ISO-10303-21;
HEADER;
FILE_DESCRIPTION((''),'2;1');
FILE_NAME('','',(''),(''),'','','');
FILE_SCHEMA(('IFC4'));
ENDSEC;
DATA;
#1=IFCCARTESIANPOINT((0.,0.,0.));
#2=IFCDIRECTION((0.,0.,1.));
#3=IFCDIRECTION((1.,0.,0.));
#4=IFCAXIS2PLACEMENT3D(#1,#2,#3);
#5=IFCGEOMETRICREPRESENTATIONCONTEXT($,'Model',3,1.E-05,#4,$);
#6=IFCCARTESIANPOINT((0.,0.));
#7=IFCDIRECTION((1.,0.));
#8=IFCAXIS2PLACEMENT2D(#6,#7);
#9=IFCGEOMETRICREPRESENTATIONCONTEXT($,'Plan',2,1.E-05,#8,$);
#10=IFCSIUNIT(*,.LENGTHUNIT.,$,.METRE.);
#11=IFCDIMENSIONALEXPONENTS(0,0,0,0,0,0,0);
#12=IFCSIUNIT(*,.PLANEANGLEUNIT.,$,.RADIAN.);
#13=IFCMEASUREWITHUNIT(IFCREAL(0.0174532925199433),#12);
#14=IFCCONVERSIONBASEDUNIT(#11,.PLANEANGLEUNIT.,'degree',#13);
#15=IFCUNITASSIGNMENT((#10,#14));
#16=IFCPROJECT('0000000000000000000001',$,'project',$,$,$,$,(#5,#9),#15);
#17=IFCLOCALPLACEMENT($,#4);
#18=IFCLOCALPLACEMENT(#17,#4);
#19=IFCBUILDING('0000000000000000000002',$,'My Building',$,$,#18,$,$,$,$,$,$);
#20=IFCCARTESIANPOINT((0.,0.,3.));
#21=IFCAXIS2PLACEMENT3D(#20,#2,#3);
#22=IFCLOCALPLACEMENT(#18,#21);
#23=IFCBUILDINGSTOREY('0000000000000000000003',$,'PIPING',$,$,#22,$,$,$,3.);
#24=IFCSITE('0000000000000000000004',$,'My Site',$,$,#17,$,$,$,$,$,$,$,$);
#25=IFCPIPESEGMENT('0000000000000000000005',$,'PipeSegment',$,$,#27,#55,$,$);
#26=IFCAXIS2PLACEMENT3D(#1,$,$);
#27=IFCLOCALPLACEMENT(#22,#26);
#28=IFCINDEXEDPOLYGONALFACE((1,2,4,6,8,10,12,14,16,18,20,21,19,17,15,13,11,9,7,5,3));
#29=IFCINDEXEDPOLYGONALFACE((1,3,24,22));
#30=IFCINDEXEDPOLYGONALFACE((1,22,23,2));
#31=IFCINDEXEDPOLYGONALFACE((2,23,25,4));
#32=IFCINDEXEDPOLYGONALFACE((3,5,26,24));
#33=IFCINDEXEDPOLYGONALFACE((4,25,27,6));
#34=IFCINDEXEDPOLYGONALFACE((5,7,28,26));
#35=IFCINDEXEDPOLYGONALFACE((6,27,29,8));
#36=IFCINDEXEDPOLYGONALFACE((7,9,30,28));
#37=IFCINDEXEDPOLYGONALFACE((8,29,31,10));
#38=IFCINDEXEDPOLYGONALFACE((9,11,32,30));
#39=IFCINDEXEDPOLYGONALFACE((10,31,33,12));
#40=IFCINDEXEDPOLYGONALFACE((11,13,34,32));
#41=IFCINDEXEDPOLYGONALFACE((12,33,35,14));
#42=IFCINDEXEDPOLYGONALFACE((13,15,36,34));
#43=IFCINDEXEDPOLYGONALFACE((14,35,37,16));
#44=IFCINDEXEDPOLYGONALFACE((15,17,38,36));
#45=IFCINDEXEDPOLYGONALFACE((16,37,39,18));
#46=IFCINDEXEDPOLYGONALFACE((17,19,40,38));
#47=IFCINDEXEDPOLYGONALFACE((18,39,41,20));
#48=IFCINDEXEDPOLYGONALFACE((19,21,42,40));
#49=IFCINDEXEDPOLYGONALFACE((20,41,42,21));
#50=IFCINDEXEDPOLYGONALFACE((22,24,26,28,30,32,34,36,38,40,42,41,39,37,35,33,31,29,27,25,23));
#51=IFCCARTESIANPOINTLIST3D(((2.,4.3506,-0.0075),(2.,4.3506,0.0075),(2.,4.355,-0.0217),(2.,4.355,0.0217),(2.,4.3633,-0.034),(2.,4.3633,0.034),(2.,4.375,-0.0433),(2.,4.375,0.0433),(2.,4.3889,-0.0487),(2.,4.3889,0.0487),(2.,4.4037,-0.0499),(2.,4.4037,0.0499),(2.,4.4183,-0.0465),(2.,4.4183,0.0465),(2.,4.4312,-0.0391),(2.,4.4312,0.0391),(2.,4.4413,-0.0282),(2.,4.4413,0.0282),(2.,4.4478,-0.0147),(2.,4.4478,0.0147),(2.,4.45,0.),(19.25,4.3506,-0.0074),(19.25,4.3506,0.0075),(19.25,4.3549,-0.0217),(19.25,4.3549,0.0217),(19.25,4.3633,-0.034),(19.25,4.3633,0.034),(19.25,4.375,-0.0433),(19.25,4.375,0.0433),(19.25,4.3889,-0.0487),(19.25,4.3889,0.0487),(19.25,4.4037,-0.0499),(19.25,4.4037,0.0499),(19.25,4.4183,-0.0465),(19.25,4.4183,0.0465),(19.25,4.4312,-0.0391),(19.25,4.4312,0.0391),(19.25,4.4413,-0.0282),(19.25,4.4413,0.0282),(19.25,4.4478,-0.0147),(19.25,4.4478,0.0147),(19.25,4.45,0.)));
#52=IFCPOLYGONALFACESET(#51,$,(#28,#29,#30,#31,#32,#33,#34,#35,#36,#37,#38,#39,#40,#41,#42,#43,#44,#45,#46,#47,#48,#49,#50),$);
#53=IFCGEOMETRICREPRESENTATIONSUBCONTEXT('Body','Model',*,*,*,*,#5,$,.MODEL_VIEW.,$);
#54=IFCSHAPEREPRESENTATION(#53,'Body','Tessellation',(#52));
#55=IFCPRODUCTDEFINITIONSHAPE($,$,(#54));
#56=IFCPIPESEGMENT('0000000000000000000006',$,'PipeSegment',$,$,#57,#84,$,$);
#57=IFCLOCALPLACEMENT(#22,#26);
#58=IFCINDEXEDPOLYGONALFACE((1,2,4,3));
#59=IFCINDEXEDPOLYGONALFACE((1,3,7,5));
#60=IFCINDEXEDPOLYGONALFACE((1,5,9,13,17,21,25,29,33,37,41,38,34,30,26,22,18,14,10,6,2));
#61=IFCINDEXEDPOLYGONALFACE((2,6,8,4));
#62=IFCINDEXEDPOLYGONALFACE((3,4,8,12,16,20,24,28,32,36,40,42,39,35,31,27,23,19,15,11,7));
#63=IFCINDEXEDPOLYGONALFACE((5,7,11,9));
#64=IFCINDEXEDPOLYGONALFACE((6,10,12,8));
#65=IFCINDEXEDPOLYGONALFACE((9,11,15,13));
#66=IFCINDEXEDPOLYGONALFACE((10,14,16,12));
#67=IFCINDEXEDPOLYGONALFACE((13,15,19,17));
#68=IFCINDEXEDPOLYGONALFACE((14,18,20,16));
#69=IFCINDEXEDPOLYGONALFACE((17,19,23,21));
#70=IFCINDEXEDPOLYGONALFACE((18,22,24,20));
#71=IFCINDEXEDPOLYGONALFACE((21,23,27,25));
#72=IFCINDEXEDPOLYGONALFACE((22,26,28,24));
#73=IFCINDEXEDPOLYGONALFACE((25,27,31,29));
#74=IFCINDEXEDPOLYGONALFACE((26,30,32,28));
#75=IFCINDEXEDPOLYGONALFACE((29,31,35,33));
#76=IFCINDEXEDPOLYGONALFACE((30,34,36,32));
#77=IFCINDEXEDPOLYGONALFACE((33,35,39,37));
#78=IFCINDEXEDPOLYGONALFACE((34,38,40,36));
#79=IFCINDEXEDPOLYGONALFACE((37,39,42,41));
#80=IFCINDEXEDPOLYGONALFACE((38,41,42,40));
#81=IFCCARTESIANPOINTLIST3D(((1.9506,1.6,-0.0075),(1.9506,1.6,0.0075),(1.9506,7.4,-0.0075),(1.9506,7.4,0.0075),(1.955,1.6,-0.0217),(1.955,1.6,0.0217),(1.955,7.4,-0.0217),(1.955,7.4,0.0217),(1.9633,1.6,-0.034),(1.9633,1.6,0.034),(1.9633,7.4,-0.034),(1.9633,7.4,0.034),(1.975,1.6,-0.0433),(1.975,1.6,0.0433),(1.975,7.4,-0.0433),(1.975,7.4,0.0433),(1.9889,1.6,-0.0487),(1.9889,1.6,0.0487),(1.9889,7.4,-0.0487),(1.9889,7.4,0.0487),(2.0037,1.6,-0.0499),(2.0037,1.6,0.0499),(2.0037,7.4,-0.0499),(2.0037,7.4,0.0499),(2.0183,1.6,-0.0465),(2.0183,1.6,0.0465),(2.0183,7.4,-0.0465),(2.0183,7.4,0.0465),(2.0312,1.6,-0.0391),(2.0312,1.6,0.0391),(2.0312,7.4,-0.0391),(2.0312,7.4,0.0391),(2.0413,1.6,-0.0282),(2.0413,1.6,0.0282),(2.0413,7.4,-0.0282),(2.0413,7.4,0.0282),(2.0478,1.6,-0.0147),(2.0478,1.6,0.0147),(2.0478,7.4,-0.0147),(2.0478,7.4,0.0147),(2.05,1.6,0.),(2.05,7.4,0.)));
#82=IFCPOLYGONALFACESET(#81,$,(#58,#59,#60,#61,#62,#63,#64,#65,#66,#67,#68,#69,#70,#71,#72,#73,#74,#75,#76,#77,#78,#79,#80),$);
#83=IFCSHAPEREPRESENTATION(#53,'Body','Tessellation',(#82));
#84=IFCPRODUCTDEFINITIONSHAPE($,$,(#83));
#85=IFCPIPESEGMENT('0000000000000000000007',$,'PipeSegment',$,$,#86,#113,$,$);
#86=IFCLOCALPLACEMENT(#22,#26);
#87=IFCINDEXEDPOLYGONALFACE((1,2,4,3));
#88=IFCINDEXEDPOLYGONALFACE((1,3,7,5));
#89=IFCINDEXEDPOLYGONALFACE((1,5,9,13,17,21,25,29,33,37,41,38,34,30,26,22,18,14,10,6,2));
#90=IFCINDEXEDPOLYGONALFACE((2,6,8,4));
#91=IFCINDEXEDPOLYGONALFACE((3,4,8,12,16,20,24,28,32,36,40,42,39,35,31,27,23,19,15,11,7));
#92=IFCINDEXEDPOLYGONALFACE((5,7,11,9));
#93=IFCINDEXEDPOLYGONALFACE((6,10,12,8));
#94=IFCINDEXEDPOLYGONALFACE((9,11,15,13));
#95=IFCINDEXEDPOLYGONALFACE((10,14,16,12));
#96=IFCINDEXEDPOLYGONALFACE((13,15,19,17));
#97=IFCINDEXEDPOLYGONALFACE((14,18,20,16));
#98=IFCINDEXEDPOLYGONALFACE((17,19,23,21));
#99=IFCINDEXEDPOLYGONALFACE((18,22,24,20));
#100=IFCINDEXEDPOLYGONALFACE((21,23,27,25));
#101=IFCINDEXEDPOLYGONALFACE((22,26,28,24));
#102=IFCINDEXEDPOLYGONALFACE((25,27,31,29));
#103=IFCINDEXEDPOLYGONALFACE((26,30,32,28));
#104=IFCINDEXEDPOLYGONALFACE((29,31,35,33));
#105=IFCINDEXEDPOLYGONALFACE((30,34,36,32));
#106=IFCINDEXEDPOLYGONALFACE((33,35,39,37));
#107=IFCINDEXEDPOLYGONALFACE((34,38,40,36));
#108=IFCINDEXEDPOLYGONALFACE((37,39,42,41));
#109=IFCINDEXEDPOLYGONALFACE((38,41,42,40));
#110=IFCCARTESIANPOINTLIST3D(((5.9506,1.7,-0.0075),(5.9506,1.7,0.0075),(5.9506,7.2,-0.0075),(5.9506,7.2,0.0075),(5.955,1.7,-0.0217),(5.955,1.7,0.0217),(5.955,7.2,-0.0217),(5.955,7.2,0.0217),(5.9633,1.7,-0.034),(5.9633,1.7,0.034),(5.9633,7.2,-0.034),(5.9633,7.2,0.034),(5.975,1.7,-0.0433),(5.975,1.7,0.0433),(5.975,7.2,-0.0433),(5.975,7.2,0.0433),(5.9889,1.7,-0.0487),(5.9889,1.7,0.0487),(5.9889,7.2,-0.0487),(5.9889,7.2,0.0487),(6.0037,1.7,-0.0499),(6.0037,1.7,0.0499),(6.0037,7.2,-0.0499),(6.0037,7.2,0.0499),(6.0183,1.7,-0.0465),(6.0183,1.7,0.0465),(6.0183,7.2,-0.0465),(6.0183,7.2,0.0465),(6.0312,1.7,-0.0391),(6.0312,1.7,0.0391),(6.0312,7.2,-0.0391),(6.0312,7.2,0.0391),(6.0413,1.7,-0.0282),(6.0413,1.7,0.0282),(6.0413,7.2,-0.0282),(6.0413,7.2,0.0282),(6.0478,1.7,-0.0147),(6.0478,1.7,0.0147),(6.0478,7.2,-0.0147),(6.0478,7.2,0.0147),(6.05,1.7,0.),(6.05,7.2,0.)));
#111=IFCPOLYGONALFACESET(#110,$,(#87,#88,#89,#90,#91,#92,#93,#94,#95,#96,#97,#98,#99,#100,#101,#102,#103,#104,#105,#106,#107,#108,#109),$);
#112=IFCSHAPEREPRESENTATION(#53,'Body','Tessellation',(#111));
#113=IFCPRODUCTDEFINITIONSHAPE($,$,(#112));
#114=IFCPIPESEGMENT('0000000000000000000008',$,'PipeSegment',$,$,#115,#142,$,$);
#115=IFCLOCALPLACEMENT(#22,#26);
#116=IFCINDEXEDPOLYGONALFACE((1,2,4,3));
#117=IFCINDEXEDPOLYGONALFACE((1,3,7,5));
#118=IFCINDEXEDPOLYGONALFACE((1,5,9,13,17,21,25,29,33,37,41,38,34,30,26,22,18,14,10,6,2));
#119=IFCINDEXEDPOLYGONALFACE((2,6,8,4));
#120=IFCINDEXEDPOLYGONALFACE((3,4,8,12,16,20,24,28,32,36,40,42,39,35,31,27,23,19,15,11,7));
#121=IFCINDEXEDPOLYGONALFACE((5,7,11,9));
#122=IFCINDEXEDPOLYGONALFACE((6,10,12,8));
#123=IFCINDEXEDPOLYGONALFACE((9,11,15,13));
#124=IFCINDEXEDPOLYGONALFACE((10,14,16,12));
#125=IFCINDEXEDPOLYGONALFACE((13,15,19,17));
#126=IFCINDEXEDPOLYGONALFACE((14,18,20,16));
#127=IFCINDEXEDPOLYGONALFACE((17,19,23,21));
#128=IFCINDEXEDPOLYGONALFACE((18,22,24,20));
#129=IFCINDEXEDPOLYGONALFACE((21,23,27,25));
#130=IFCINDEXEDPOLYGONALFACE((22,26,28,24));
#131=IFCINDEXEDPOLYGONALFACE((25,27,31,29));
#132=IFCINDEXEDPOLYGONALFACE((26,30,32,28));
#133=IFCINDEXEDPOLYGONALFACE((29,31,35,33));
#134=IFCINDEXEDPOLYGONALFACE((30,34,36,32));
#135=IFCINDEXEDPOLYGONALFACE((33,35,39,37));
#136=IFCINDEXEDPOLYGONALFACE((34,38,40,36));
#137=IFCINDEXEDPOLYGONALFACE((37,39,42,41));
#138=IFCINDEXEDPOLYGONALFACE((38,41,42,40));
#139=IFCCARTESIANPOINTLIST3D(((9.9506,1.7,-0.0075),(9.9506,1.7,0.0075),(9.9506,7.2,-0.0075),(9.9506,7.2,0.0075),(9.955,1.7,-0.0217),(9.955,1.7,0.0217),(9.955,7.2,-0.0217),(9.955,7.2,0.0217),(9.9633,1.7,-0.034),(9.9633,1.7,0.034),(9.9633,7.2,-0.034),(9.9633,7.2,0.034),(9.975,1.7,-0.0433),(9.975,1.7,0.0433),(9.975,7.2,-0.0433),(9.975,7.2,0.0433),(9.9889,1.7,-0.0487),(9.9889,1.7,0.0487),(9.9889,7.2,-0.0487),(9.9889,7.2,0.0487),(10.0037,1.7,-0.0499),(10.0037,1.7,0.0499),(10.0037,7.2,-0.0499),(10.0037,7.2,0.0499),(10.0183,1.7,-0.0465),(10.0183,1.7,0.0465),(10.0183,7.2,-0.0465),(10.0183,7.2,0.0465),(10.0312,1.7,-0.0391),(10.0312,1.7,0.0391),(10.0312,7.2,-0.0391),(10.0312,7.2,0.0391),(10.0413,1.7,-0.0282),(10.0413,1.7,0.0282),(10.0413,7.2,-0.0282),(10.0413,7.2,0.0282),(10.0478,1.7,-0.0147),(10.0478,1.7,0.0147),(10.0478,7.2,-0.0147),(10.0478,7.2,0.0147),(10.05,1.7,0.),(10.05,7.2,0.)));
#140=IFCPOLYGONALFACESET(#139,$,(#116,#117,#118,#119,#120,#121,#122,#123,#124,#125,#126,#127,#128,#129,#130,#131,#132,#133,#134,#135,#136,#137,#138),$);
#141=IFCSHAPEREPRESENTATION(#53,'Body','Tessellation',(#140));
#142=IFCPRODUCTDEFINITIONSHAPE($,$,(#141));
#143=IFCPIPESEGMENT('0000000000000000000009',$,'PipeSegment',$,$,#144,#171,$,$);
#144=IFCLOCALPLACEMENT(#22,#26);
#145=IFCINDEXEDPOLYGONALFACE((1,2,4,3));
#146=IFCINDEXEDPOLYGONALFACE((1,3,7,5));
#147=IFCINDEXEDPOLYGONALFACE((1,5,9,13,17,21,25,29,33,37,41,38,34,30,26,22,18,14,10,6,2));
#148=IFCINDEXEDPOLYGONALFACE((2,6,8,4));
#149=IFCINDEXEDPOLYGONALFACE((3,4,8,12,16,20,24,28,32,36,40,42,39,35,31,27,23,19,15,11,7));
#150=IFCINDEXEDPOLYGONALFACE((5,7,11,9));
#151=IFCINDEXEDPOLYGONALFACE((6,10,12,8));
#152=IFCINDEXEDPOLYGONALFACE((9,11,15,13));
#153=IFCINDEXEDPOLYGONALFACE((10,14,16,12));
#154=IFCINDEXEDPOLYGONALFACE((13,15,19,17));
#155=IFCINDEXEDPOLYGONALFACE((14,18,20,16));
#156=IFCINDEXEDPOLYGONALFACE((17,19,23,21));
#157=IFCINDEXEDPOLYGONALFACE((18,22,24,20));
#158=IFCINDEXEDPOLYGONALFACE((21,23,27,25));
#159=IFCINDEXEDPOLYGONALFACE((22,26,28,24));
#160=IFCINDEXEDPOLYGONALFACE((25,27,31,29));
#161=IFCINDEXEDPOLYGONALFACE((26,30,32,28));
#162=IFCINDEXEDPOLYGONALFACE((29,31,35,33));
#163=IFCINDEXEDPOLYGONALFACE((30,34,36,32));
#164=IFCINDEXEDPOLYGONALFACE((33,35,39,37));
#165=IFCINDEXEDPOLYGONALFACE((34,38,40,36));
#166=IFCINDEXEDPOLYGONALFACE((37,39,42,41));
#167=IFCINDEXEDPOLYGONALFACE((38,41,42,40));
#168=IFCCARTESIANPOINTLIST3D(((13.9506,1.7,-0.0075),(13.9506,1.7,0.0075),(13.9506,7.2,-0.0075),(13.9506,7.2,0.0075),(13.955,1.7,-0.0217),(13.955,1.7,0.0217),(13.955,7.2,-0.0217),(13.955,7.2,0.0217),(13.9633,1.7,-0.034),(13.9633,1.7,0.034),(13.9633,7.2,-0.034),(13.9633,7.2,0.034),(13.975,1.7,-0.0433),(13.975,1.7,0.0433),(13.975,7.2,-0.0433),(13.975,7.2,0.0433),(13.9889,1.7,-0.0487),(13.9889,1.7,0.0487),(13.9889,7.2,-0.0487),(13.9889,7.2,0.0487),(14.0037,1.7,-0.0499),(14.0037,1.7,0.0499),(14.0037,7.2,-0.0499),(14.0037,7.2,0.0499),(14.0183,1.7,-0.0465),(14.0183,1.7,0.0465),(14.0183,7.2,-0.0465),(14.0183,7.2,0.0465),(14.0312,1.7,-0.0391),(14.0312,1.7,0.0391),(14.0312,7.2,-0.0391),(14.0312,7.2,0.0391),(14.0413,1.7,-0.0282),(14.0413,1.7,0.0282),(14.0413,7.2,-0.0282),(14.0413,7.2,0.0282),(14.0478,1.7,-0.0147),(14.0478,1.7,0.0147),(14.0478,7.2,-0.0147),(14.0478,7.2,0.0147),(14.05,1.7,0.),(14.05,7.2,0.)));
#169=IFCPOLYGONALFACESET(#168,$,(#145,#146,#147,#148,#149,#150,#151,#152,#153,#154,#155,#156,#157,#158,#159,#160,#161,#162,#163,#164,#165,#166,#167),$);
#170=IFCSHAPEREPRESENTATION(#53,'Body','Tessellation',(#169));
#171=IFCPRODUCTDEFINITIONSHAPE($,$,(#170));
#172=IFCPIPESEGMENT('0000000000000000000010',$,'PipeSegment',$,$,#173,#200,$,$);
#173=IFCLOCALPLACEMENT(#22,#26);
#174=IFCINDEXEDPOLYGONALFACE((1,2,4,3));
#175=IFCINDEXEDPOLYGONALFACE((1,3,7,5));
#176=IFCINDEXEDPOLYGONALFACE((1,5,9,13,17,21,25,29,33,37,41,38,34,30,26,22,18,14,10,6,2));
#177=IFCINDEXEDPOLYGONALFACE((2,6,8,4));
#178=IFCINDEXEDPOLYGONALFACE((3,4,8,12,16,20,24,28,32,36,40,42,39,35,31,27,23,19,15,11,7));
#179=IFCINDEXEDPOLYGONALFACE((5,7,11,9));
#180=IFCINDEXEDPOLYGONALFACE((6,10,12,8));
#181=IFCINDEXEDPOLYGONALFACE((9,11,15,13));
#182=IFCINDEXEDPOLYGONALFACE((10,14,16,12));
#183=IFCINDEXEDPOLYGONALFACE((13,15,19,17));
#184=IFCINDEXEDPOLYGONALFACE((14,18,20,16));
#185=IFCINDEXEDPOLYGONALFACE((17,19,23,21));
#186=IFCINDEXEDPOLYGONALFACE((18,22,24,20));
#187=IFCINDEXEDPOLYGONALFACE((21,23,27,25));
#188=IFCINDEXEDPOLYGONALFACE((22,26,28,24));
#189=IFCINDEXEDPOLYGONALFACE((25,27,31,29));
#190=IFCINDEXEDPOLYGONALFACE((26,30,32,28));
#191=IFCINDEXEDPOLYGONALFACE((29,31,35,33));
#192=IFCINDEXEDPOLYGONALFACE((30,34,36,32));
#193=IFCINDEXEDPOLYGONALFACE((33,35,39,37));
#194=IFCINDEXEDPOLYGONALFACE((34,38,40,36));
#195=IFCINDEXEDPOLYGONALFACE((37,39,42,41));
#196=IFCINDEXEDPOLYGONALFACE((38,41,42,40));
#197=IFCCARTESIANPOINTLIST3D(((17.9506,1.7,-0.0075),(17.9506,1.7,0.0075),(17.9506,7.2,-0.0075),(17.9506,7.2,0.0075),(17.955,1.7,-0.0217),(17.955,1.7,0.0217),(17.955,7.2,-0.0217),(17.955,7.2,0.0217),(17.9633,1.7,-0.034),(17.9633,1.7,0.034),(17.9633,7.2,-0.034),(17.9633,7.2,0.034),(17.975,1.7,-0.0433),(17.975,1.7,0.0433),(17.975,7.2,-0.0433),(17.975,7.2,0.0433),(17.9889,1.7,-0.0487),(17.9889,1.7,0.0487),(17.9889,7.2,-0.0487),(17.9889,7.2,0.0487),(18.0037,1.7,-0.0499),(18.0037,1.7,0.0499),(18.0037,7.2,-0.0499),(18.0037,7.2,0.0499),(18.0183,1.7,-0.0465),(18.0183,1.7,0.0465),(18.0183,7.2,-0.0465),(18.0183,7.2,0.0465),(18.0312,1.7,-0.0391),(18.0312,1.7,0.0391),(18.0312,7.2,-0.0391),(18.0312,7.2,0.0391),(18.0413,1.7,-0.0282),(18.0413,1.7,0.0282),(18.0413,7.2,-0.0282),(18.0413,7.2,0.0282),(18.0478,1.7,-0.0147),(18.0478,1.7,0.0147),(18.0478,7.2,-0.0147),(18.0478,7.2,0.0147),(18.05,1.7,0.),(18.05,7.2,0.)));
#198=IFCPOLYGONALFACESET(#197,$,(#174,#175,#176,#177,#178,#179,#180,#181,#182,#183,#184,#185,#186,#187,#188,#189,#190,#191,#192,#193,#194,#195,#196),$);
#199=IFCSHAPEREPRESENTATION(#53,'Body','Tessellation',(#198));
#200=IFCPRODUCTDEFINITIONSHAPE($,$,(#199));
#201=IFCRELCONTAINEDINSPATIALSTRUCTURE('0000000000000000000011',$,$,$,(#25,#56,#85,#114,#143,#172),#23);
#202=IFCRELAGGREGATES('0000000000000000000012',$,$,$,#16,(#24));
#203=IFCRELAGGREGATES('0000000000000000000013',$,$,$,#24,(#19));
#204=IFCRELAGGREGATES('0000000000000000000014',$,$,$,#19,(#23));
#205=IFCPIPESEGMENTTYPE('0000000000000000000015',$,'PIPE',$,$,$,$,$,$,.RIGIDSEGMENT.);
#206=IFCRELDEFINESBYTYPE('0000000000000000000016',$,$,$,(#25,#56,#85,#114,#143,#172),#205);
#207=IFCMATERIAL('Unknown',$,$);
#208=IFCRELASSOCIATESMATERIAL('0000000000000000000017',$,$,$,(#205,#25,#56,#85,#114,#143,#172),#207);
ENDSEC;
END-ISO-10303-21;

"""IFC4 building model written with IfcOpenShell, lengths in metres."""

from ifc_helpers import new_model, entity, si_unit, converted_unit, frame, origin_with_axes, origin_2d_with_axis, place, context, subcontext, project, spatial, circle, extrude, material, material_profile, profile_set, profile_usage, type_object, element, save


model = new_model("IFC4")

# Units and contexts
model_context = context("Model", 3, precision=1e-05, world=origin_with_axes())
plan_context = context("Plan", 2, precision=1e-05, world=origin_2d_with_axis())
body_context = subcontext(model_context, "Body", "Model", "MODEL_VIEW")
ifc_project = project(units=[si_unit("LENGTHUNIT", "METRE"), converted_unit("PLANEANGLEUNIT", "degree", entity("IfcReal", 0.0174532925199433), si_unit("PLANEANGLEUNIT", "RADIAN"), dimensions=[0, 0, 0, 0, 0, 0, 0])], contexts=[model_context, plan_context])

# Site, building, storey
site_placement = place(None, origin_with_axes())
site = spatial("IfcSite", under=ifc_project, at=site_placement, Name="My Site")
building_placement = place(site_placement, origin_with_axes())
building = spatial("IfcBuilding", under=site, at=building_placement, Name="My Building")
storey_placement = place(building_placement, frame((0.0, 0.0, 3.0), z_axis=(0.0, 0.0, 1.0), x_axis=(1.0, 0.0, 0.0)))
storey = spatial("IfcBuildingStorey", under=building, at=storey_placement, Name="PIPING", Elevation=3.0)

# Pipe segments
ifc_material = material(Name="Unknown")
ifc_material_profile_1 = material_profile(ifc_material, circle(Radius=0.05))
ifc_profile_set_1 = profile_set([ifc_material_profile_1])
ifc_profile_usage_1 = profile_usage(ifc_profile_set_1, cardinal=5)
pipe_segment_type = type_object("IfcPipeSegmentType", Name="PIPE", PredefinedType="RIGIDSEGMENT", material=ifc_profile_set_1)
pipe_segment_1_placement = place(storey_placement, frame((2.0, 4.4, 0.0), z_axis=(1.0, 0.0, 0.0), x_axis=(0.0, 1.0, 0.0)))
element("IfcPipeSegment", 1, at=pipe_segment_1_placement, inside=storey, type_object=pipe_segment_type, material=ifc_profile_usage_1, Name="PipeSegment", context=body_context, shape_type="SweptSolid", body=[
    extrude(circle(Radius=0.05), origin_with_axes(), (0.0, 0.0, 1.0), 17.25),
])
ifc_profile_usage_2 = profile_usage(ifc_profile_set_1, cardinal=5)
pipe_segment_2_placement = place(storey_placement, frame((2.0, 7.4, 0.0), z_axis=(0.0, -1.0, 0.0), x_axis=(1.0, 0.0, 0.0)))
element("IfcPipeSegment", 2, at=pipe_segment_2_placement, inside=storey, type_object=pipe_segment_type, material=ifc_profile_usage_2, Name="PipeSegment", context=body_context, shape_type="SweptSolid", body=[
    extrude(circle(Radius=0.05), origin_with_axes(), (0.0, 0.0, 1.0), 5.8),
])
ifc_profile_usage_3 = profile_usage(ifc_profile_set_1, cardinal=5)
pipe_segment_3_placement = place(storey_placement, frame((6.0, 7.2, 0.0), z_axis=(0.0, -1.0, 0.0), x_axis=(1.0, 0.0, 0.0)))
element("IfcPipeSegment", 3, at=pipe_segment_3_placement, inside=storey, type_object=pipe_segment_type, material=ifc_profile_usage_3, Name="PipeSegment", context=body_context, shape_type="SweptSolid", body=[
    extrude(circle(Radius=0.05), origin_with_axes(), (0.0, 0.0, 1.0), 5.5),
])
ifc_profile_usage_4 = profile_usage(ifc_profile_set_1, cardinal=5)
pipe_segment_4_placement = place(storey_placement, frame((10.0, 7.2, 0.0), z_axis=(0.0, -1.0, 0.0), x_axis=(1.0, 0.0, 0.0)))
element("IfcPipeSegment", 4, at=pipe_segment_4_placement, inside=storey, type_object=pipe_segment_type, material=ifc_profile_usage_4, Name="PipeSegment", context=body_context, shape_type="SweptSolid", body=[
    extrude(circle(Radius=0.05), origin_with_axes(), (0.0, 0.0, 1.0), 5.5),
])
ifc_profile_usage_5 = profile_usage(ifc_profile_set_1, cardinal=5)
pipe_segment_5_placement = place(storey_placement, frame((14.0, 7.2, 0.0), z_axis=(0.0, -1.0, 0.0), x_axis=(1.0, 0.0, 0.0)))
element("IfcPipeSegment", 5, at=pipe_segment_5_placement, inside=storey, type_object=pipe_segment_type, material=ifc_profile_usage_5, Name="PipeSegment", context=body_context, shape_type="SweptSolid", body=[
    extrude(circle(Radius=0.05), origin_with_axes(), (0.0, 0.0, 1.0), 5.5),
])
ifc_profile_usage_6 = profile_usage(ifc_profile_set_1, cardinal=5)
pipe_segment_6_placement = place(storey_placement, frame((18.0, 7.2, 0.0), z_axis=(0.0, -1.0, 0.0), x_axis=(1.0, 0.0, 0.0)))
element("IfcPipeSegment", 6, at=pipe_segment_6_placement, inside=storey, type_object=pipe_segment_type, material=ifc_profile_usage_6, Name="PipeSegment", context=body_context, shape_type="SweptSolid", body=[
    extrude(circle(Radius=0.05), origin_with_axes(), (0.0, 0.0, 1.0), 5.5),
])

save(model, "model.ifc")
